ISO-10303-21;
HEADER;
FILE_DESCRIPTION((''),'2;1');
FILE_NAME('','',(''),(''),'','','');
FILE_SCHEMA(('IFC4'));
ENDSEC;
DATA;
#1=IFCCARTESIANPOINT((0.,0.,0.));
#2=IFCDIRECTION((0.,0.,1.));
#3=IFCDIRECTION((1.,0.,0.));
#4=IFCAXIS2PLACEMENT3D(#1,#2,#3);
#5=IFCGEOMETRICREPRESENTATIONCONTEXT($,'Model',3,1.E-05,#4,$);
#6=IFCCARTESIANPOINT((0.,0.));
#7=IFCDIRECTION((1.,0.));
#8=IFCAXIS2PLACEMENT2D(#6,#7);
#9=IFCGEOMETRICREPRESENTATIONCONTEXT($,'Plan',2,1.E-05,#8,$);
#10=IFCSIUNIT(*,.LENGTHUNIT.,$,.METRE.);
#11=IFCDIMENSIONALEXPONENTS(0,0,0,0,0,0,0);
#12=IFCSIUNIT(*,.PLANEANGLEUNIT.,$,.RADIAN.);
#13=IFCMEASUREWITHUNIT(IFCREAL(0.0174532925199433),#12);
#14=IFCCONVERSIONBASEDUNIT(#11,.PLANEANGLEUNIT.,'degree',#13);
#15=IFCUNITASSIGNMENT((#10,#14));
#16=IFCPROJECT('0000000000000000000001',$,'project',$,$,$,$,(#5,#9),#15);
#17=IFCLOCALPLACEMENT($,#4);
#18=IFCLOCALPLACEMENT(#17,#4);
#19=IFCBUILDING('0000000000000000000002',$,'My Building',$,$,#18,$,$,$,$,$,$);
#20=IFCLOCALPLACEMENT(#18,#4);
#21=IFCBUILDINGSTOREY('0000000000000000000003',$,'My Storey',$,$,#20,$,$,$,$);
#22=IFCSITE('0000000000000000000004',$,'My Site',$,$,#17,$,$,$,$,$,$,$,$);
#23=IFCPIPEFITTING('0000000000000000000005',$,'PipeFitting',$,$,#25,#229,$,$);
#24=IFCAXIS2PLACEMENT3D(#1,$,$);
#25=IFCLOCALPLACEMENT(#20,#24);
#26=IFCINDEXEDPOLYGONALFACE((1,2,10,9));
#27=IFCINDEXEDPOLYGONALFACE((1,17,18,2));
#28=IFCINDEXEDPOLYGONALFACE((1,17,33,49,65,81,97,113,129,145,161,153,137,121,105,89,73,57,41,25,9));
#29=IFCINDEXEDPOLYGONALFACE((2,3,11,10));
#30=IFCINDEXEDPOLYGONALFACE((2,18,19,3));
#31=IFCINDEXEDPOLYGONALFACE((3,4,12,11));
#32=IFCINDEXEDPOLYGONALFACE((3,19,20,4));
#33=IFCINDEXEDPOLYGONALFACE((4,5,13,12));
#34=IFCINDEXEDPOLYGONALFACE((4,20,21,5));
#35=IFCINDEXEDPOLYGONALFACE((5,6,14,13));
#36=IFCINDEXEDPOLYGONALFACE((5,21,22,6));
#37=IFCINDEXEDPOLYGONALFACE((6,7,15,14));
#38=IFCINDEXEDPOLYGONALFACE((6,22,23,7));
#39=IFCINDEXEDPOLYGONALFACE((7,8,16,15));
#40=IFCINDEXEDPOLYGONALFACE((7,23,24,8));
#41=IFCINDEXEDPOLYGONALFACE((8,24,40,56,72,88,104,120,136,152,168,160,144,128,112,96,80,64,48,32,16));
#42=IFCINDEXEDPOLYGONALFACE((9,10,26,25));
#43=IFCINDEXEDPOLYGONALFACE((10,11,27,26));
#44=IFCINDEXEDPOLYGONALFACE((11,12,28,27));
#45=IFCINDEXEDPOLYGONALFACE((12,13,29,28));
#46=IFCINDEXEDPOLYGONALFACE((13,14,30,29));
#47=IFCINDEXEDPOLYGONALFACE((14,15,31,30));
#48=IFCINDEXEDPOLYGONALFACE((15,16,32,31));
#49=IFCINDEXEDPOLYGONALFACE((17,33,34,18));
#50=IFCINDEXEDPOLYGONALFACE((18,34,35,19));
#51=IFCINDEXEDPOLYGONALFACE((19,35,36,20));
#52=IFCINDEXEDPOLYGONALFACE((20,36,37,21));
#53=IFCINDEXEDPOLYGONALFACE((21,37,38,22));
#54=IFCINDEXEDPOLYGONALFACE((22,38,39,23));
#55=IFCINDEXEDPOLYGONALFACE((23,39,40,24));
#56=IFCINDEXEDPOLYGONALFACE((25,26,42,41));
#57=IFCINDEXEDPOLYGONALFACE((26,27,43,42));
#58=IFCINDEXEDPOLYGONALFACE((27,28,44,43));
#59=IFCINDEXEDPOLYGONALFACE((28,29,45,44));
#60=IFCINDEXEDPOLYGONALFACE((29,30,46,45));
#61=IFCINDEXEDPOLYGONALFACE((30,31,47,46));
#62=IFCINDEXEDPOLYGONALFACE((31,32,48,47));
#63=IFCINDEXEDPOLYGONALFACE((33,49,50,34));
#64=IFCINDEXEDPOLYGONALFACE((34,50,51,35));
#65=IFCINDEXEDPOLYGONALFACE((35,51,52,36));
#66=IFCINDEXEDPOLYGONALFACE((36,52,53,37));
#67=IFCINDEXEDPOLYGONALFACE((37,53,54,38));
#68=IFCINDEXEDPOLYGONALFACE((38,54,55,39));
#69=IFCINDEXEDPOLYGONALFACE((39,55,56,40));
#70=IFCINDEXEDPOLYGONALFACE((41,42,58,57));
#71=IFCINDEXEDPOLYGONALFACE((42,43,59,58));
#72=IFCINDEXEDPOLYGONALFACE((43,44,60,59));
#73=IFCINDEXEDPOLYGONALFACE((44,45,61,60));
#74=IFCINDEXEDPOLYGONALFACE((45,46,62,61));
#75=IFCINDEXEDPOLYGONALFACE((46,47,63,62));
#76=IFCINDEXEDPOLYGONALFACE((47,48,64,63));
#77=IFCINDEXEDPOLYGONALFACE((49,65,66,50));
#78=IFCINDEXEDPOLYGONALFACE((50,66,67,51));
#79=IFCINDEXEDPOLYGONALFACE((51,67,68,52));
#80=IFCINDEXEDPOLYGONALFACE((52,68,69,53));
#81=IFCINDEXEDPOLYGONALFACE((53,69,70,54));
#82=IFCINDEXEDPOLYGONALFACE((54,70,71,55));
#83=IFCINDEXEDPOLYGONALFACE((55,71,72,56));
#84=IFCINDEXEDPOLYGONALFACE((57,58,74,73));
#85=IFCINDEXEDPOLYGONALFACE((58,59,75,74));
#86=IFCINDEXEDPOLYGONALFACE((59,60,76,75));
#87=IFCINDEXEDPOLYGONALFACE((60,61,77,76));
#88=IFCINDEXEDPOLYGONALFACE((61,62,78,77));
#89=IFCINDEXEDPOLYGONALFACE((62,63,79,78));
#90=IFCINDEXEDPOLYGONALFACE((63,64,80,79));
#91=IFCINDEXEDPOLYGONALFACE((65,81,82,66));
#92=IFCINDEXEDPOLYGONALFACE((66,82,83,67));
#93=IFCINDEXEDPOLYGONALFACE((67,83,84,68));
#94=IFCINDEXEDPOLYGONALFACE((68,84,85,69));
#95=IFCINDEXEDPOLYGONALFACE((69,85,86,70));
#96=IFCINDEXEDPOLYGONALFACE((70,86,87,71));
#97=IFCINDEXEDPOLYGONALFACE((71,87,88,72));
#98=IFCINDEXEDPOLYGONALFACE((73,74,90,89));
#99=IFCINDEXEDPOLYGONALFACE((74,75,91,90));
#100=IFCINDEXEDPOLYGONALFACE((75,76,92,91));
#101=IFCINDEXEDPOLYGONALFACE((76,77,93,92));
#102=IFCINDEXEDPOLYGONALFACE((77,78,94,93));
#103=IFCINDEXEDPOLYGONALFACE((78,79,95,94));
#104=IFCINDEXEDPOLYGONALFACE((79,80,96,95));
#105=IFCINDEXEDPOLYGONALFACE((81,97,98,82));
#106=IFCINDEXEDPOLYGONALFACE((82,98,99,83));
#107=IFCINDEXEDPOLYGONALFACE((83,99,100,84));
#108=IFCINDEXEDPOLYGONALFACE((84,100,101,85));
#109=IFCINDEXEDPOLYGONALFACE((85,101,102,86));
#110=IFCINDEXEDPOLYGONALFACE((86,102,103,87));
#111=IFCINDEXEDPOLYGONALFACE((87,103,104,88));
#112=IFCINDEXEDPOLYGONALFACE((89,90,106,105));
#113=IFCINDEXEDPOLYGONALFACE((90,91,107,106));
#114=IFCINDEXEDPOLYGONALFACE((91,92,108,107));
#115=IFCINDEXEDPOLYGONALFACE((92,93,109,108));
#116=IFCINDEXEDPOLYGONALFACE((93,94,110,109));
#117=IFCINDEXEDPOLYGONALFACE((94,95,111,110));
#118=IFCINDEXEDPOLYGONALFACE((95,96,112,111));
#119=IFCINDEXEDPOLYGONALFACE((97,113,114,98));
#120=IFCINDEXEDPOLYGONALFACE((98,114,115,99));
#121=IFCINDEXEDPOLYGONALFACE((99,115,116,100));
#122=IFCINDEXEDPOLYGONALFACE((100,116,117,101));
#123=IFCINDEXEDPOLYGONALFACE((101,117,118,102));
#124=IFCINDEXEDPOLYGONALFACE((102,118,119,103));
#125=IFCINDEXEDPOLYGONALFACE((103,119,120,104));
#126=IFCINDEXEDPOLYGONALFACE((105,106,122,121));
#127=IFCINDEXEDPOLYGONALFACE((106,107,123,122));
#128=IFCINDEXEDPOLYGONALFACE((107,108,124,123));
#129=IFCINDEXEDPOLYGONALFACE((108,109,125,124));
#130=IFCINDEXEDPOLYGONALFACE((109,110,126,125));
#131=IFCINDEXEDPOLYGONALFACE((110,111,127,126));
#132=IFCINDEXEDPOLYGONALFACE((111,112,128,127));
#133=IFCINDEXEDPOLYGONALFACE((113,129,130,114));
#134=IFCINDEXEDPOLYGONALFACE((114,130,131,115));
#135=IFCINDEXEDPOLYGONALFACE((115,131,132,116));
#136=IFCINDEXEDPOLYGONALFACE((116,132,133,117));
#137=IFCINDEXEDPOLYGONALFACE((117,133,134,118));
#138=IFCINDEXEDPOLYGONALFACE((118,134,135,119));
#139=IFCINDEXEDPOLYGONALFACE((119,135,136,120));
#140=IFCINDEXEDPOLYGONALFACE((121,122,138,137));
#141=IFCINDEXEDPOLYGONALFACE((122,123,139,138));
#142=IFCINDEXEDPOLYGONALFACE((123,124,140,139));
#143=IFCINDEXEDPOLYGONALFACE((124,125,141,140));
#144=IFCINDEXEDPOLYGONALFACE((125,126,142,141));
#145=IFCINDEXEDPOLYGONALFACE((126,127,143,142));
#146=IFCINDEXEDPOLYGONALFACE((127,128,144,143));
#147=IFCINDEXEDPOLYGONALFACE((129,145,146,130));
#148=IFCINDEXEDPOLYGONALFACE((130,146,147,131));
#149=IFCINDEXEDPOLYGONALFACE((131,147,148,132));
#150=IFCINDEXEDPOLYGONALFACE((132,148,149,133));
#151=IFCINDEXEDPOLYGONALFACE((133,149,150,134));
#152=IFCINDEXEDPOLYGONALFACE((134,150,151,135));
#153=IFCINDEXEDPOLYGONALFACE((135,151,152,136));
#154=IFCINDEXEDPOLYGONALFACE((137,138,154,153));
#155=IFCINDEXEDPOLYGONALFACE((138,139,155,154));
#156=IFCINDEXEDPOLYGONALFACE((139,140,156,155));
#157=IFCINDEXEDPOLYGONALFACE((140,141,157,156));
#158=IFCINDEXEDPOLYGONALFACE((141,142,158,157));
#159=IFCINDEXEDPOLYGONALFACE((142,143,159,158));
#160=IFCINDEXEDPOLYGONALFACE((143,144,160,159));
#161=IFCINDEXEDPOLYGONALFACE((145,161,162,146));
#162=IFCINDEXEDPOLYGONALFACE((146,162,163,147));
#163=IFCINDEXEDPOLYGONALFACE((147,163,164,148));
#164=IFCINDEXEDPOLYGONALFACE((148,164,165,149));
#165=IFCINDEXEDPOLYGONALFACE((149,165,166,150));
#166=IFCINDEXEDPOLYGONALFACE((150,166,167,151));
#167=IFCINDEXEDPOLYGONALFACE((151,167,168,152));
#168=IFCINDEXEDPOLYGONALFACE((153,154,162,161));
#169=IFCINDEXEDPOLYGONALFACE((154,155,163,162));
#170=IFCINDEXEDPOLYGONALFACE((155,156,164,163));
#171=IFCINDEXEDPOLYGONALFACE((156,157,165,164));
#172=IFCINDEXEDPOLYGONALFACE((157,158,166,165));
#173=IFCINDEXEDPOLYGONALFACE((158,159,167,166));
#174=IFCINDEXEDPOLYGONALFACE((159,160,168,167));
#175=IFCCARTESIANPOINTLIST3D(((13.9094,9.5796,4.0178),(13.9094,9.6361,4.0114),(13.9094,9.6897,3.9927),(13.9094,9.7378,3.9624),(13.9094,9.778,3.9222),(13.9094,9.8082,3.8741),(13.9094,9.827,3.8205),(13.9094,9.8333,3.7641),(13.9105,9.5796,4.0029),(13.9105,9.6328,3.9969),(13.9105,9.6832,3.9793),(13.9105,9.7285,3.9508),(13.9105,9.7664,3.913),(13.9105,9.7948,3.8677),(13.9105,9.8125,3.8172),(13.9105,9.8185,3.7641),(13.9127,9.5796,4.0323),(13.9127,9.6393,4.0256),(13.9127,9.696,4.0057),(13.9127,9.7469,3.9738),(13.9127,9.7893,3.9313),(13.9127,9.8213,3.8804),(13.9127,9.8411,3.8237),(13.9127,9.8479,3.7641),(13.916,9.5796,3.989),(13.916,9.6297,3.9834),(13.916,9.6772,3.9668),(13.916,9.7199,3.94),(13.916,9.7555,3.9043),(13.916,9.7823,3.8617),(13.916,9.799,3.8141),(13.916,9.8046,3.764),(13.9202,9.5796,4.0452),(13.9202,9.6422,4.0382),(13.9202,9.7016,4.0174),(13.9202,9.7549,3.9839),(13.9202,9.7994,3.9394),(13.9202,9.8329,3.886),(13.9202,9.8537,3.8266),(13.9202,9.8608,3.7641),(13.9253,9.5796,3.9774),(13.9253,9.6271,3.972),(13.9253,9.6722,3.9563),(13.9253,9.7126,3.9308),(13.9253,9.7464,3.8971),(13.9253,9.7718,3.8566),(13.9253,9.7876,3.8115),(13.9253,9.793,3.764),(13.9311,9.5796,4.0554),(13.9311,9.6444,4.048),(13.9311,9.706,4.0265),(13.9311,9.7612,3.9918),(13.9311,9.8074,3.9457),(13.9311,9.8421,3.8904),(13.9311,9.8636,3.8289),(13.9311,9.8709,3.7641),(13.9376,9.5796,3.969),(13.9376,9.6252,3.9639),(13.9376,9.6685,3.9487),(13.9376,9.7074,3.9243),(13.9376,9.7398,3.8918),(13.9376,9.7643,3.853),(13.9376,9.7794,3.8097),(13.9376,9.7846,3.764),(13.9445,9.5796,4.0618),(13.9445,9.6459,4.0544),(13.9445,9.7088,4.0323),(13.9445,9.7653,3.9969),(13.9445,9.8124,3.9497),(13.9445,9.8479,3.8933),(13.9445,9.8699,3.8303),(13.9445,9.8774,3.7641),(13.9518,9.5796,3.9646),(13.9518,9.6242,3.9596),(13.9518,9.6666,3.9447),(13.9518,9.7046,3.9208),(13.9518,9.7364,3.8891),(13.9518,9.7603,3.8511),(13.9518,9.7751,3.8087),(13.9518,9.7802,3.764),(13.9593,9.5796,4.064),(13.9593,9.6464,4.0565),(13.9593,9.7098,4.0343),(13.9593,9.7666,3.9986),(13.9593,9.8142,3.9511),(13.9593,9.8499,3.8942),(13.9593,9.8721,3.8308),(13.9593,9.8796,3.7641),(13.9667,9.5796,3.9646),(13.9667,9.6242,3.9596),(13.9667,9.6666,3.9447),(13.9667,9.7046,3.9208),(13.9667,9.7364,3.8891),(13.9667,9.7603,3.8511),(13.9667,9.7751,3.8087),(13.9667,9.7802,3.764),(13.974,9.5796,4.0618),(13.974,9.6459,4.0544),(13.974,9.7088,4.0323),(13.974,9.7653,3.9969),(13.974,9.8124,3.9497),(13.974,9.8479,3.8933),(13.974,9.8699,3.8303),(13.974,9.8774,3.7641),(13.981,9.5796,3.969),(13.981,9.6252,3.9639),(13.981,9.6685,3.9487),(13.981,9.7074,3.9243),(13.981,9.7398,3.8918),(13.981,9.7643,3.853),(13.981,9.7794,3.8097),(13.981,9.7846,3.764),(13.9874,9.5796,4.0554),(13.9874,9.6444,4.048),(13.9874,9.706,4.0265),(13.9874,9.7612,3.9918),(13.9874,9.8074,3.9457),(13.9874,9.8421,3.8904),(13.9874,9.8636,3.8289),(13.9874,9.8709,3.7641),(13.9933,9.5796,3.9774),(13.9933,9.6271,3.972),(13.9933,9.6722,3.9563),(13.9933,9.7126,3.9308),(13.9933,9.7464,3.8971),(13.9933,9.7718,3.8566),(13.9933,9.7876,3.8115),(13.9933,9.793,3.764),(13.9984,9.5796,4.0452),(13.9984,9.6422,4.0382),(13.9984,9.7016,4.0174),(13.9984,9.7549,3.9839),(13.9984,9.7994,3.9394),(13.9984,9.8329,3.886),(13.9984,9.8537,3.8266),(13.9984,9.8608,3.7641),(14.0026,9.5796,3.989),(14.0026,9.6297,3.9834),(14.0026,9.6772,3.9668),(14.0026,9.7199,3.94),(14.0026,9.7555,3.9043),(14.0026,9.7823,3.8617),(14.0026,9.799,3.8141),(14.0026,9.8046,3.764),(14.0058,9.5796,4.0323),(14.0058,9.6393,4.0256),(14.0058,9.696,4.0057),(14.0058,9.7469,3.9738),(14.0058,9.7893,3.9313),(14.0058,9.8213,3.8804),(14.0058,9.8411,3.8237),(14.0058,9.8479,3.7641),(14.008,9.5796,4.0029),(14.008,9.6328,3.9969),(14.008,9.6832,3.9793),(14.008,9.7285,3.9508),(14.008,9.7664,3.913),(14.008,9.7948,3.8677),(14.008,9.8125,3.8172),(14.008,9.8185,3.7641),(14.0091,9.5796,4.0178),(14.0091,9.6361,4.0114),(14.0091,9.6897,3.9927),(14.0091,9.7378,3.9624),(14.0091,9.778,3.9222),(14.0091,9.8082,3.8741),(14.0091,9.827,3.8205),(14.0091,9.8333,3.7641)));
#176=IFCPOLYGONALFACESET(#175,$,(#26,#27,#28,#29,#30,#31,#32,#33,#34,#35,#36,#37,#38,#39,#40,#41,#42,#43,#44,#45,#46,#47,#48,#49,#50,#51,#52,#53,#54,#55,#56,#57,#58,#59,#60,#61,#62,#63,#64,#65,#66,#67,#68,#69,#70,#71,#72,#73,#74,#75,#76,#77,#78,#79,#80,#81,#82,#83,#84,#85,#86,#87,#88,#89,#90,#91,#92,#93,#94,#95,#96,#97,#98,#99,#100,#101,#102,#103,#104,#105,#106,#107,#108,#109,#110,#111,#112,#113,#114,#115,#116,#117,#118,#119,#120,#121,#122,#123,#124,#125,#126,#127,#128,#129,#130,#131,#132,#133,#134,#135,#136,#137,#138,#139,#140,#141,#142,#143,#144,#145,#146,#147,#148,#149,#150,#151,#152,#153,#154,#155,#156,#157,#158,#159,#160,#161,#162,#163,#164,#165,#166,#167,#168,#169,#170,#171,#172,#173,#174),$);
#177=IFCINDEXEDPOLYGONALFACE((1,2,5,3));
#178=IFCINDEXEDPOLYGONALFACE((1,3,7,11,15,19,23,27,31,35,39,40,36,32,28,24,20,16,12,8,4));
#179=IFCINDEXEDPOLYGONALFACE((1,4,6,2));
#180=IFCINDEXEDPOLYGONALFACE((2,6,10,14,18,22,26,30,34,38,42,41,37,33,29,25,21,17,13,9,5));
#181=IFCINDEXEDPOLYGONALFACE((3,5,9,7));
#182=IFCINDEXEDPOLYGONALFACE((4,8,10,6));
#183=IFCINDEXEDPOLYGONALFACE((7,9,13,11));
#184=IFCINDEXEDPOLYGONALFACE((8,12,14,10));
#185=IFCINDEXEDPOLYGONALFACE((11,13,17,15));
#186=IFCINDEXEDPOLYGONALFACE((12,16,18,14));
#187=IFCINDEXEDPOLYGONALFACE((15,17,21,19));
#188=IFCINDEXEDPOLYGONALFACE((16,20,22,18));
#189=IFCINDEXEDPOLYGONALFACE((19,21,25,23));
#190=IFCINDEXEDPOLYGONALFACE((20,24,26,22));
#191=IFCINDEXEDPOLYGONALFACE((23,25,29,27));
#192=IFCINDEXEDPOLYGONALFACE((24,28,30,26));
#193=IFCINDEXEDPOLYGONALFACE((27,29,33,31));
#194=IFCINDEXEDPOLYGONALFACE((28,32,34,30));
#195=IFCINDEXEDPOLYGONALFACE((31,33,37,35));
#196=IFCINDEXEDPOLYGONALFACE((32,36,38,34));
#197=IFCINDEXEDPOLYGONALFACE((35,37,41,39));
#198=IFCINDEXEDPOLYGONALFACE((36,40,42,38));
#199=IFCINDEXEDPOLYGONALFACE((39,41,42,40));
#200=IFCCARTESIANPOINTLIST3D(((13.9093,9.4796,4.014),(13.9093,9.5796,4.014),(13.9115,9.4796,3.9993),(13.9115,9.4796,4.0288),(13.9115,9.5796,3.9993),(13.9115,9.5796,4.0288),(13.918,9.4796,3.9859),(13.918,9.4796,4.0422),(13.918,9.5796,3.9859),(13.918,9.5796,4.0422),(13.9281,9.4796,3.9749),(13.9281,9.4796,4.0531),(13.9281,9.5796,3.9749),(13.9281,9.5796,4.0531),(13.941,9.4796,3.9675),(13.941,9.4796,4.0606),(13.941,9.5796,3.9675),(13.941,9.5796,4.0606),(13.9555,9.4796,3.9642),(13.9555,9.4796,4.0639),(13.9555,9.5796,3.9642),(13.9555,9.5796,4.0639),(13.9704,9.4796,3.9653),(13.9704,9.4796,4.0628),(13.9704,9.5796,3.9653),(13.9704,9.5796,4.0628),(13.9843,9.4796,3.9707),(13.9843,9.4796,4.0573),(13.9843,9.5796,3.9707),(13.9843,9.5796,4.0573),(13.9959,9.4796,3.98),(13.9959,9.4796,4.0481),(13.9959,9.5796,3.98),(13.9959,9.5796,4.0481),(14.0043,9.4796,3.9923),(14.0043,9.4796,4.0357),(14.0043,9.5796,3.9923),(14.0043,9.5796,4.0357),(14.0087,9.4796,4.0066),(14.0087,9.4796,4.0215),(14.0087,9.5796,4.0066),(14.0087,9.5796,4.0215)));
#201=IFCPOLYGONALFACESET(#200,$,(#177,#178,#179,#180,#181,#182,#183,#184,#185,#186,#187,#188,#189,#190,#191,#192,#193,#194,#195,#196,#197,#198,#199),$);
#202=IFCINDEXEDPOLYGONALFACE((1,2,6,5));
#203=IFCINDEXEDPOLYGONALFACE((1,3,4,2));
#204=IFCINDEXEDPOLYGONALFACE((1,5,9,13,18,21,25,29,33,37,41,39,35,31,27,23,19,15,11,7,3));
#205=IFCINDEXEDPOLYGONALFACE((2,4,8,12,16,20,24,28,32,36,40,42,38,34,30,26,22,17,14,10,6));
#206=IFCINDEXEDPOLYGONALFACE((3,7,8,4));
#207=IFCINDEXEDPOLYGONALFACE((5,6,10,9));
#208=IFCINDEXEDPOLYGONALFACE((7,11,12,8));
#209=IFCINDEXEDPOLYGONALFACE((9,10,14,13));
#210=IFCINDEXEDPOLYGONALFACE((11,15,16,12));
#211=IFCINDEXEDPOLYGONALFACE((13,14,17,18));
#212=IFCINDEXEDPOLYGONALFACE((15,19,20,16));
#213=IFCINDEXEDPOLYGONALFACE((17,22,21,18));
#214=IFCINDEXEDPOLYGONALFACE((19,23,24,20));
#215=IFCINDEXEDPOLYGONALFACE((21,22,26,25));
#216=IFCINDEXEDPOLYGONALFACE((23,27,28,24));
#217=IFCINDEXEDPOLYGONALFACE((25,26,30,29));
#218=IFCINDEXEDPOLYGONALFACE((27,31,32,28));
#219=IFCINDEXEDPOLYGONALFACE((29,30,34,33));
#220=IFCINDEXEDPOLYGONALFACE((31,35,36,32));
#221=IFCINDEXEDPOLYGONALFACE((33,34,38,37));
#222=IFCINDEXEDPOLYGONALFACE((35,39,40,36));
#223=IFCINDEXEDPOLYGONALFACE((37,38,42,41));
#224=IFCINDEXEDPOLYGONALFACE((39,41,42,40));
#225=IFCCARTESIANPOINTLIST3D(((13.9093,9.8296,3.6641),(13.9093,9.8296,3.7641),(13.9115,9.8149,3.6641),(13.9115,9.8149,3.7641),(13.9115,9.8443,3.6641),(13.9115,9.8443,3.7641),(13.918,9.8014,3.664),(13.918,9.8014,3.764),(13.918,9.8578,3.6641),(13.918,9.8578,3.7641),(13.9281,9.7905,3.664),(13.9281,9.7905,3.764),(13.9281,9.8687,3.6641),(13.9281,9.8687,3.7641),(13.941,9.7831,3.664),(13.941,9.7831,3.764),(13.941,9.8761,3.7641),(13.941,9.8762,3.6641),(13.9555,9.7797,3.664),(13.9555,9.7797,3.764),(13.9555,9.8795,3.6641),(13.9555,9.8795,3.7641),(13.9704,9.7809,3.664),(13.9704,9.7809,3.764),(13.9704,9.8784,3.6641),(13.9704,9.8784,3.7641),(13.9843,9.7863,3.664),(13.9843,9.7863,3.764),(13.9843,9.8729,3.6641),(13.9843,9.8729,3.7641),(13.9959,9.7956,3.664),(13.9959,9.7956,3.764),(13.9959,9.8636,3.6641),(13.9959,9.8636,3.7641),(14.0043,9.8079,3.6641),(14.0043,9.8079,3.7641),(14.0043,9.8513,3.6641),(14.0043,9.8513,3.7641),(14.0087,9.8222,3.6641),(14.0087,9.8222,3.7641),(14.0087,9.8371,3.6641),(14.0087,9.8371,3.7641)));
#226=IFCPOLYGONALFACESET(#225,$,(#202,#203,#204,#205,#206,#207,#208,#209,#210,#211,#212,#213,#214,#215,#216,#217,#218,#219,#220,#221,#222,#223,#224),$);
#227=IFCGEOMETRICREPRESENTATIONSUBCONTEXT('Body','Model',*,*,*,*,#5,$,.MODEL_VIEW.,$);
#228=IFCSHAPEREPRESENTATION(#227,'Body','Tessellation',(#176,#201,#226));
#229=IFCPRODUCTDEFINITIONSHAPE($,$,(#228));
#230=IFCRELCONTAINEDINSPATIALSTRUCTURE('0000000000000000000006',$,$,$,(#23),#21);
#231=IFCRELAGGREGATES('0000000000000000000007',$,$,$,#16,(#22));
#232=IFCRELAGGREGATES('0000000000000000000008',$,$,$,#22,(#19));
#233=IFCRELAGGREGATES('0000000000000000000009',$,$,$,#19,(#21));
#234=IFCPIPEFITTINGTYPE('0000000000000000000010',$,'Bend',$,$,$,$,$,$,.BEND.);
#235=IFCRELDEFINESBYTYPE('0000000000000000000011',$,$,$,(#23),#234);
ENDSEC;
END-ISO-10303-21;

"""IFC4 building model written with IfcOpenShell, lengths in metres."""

from ifc_helpers import new_model, entity, si_unit, converted_unit, frame, origin_with_axes, origin_2d_with_axis, place, context, subcontext, project, spatial, circle, extrude, source, transform, mapped, type_object, type_shapes, element, save


model = new_model("IFC4")

# Units and contexts
model_context = context("Model", 3, precision=1e-05, world=origin_with_axes())
plan_context = context("Plan", 2, precision=1e-05, world=origin_2d_with_axis())
body_context_1 = subcontext(model_context, "Body", "Model", "MODEL_VIEW")
ifc_project = project(units=[si_unit("LENGTHUNIT", "METRE"), converted_unit("PLANEANGLEUNIT", "degree", entity("IfcReal", 0.0174532925199433), si_unit("PLANEANGLEUNIT", "RADIAN"), dimensions=[0, 0, 0, 0, 0, 0, 0])], contexts=[model_context, plan_context])

# Site, building, storey
site_placement = place(None, origin_with_axes())
site = spatial("IfcSite", under=ifc_project, at=site_placement, Name="My Site")
building_placement = place(site_placement, origin_with_axes())
building = spatial("IfcBuilding", under=site, at=building_placement, Name="My Building")
storey_placement = place(building_placement, origin_with_axes())
storey = spatial("IfcBuildingStorey", under=building, at=storey_placement, Name="My Storey")

# Pipe fitting
pipe_fitting_type_1 = type_object("IfcPipeFittingType", Name="Bend", PredefinedType="BEND")
shared_shape_1 = source(origin_with_axes(), body_context_1, "Body", "SolidModel", [
    entity("IfcSweptDiskSolid", entity("IfcIndexedPolyCurve", entity("IfcCartesianPointList3D", [[0.0, 0.0, 0.1], [0.0, -0.0732, 0.2768], [0.0, -0.25, 0.35]]), [entity("IfcArcIndex", [1, 2, 3])]), 0.05),
    extrude(circle(Radius=0.05), origin_with_axes(), (0.0, 0.0, 1.0), 0.1),
    extrude(circle(Radius=0.05), frame((0.0, -0.25, 0.35), z_axis=(0.0, -1.0, 0.000038), x_axis=(1.0, 0.0, 0.0)), (0.0, 0.0, 1.0), 0.1),
])
type_shapes(pipe_fitting_type_1, [shared_shape_1])
for number, where, z_axis, x_axis, name in (
    (1, (13.9593, 9.4796, 4.014), (0.0, 1.0, 0.0), (-1.0, 0.0, 0.0), "PipeFitting"),
):
    element("IfcPipeFitting", number, at=place(storey_placement, frame(where, z_axis=z_axis, x_axis=x_axis)), inside=storey, type_object=pipe_fitting_type_1, Name=name, context=body_context_1, shape_type="MappedRepresentation", body=[
        mapped(shared_shape_1, transform((0.0, 0.0, 0.0), x_axis=(1.0, 0.0, 0.0), y_axis=(0.0, 1.0, 0.0), z_axis=(0.0, 0.0, 1.0), scale=1.0)),
    ])

save(model, "model.ifc")
